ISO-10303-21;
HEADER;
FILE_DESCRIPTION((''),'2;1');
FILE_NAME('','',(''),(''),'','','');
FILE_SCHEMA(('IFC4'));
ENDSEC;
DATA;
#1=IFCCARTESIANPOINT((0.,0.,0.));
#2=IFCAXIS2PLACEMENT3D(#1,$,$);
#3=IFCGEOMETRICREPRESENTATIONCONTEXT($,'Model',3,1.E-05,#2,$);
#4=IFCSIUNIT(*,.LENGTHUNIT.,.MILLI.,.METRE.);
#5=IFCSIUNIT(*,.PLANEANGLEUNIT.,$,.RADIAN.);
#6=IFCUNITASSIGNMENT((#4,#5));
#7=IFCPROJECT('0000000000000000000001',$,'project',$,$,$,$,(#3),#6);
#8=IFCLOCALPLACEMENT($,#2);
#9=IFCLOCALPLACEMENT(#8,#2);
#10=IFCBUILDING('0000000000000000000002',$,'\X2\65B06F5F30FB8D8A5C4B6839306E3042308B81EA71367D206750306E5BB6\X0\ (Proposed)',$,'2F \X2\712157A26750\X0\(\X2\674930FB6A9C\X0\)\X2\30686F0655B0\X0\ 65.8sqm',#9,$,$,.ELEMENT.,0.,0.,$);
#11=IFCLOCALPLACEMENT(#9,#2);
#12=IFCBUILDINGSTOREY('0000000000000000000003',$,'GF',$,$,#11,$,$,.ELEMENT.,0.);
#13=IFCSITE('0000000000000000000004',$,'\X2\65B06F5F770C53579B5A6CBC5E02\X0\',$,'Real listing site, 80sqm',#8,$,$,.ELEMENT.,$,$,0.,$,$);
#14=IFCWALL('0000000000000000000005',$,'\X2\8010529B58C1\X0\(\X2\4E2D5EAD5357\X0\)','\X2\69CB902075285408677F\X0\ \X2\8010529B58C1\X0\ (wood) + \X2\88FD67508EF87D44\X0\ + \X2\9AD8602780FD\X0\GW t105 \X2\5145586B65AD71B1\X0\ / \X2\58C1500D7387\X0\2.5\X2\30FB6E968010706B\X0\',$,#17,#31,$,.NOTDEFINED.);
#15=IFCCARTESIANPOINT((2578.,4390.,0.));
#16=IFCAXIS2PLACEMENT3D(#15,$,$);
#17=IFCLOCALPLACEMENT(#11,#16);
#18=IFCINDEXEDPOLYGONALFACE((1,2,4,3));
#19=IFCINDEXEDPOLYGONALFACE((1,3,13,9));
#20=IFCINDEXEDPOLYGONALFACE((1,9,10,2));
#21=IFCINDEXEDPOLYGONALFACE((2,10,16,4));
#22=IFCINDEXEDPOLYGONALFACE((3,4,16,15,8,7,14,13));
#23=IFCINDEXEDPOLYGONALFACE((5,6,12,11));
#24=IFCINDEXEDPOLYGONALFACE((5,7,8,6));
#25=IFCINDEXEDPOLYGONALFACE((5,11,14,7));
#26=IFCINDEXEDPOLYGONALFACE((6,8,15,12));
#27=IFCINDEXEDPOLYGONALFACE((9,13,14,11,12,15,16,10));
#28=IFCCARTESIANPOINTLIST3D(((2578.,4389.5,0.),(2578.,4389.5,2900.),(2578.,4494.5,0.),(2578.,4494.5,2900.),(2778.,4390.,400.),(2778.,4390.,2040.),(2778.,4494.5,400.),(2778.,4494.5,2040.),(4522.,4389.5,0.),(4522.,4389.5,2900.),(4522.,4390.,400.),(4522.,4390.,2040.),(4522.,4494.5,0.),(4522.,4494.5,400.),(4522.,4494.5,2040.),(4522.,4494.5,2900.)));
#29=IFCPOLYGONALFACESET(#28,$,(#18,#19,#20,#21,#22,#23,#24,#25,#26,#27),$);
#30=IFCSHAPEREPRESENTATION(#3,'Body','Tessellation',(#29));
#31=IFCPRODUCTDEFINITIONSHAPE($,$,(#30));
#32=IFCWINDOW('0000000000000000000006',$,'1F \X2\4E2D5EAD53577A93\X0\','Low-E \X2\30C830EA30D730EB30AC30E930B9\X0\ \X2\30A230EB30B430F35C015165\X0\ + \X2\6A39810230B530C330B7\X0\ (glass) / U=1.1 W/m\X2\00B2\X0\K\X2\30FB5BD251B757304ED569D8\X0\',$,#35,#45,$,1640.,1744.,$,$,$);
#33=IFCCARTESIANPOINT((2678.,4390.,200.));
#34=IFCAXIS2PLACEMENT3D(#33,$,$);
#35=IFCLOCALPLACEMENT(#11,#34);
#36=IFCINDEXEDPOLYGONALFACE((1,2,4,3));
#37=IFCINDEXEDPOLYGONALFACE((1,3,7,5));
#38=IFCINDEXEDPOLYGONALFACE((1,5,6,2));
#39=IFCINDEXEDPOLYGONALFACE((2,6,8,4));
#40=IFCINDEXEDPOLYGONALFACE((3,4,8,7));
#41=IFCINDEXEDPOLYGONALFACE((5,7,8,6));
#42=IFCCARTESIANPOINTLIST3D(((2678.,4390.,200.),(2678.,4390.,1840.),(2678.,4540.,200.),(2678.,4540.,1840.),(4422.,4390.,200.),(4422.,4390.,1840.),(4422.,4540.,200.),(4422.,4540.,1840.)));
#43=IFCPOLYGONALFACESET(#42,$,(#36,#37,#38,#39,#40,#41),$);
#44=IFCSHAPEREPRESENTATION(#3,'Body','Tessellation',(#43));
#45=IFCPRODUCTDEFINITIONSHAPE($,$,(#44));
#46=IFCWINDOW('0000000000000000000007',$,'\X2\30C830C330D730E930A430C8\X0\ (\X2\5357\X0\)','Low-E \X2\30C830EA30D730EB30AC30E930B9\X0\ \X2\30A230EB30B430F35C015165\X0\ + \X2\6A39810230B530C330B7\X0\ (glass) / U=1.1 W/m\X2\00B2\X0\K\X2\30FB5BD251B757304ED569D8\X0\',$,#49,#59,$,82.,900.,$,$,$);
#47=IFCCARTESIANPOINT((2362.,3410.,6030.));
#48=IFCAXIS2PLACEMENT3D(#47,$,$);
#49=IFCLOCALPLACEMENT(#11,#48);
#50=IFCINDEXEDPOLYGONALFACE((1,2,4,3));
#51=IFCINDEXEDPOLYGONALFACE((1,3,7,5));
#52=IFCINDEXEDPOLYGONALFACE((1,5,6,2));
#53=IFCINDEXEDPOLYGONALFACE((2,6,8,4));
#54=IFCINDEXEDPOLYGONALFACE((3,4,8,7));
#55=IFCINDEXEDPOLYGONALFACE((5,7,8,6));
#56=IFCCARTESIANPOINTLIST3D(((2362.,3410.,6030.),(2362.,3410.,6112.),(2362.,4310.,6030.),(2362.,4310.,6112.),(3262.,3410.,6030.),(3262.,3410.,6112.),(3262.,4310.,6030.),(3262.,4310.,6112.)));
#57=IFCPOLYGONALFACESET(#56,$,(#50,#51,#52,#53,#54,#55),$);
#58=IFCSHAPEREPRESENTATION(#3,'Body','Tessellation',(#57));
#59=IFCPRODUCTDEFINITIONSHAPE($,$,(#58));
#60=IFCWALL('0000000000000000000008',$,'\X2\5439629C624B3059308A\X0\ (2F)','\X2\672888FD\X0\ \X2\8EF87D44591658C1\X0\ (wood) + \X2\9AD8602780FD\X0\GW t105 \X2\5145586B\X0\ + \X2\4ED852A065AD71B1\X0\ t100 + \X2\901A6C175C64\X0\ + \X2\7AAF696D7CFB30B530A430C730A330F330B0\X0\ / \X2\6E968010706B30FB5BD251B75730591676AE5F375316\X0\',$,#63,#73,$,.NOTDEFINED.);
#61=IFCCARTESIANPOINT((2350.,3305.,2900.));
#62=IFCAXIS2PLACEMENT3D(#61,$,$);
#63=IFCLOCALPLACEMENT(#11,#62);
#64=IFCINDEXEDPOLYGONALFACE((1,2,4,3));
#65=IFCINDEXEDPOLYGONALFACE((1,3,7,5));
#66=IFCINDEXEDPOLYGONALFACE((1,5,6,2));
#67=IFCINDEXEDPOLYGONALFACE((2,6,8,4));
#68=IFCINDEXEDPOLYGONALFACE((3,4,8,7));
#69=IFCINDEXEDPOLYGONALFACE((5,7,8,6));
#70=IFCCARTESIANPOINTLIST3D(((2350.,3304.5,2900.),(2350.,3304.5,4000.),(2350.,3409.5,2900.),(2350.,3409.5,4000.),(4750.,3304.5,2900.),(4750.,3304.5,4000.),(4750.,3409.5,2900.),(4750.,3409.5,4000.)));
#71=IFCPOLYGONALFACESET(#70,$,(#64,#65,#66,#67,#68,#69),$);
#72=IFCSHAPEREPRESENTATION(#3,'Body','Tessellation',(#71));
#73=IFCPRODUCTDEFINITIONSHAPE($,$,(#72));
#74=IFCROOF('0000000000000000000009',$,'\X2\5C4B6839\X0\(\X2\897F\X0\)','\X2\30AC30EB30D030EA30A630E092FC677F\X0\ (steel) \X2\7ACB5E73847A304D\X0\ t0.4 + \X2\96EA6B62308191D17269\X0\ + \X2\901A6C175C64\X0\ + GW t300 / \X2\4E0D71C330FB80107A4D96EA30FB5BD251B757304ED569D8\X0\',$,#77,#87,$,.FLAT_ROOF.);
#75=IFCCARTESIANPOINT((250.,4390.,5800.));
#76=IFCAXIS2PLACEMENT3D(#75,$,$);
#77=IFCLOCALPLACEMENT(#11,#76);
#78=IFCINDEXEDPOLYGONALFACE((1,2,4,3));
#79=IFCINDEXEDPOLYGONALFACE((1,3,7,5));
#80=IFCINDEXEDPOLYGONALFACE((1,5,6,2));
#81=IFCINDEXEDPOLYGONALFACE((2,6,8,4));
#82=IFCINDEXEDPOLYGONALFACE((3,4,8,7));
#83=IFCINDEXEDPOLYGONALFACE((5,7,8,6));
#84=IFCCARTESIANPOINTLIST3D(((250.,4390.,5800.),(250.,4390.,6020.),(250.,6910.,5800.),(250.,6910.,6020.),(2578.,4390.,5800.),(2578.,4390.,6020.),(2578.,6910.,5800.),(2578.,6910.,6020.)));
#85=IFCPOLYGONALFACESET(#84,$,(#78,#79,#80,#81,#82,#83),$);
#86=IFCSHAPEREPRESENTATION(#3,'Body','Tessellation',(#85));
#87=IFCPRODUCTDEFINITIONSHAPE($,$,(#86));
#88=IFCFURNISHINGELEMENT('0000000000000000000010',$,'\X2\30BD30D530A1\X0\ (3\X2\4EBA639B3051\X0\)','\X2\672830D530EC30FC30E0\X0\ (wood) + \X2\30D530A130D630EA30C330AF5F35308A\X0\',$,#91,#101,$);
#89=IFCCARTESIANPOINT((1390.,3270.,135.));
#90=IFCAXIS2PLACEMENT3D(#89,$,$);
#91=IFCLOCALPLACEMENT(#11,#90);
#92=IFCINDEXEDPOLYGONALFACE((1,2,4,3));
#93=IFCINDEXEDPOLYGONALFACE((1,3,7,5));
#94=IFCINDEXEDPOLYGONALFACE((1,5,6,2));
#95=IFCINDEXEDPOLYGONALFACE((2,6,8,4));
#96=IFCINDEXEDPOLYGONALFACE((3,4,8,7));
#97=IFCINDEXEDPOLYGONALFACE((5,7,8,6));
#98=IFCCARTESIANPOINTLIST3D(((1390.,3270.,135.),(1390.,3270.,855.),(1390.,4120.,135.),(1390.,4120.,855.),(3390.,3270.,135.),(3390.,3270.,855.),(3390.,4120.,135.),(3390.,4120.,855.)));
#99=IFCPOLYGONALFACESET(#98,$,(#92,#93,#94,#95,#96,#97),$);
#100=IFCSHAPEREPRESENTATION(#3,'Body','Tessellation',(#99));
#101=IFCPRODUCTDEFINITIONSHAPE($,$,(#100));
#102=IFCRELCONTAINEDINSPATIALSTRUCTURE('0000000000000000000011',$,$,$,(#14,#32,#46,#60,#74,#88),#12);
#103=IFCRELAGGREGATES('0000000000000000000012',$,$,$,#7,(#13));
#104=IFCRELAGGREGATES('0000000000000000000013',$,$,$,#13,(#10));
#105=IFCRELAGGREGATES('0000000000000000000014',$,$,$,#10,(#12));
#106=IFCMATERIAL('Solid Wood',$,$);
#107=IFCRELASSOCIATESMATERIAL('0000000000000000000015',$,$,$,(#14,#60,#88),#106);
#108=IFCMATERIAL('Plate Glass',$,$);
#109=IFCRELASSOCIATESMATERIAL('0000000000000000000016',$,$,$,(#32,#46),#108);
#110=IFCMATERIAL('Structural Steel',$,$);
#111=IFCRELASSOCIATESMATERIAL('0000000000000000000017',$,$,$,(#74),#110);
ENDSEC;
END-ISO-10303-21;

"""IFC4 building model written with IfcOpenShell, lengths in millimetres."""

from ifc_helpers import new_model, si_unit, frame, frame_2d, origin, place, context, project, spatial, rectangle, extrude, material, element, fill, save


model = new_model("IFC4")

# Units and contexts
model_context = context("Model", 3, precision=1e-05, world=origin())
ifc_project = project(units=[si_unit("LENGTHUNIT", "METRE", prefix="MILLI"), si_unit("PLANEANGLEUNIT", "RADIAN")], contexts=[model_context])

# Site, building, storey
site_placement = place(None, origin())
site = spatial("IfcSite", under=ifc_project, at=site_placement, Name="新潟県南魚沼市", ObjectType="Real listing site, 80sqm", CompositionType="ELEMENT", RefElevation=0.0)
building_placement = place(site_placement, origin())
building = spatial("IfcBuilding", under=site, at=building_placement, Name="新潟・越屋根のある自然素材の家 (Proposed)", ObjectType="2F 無垢材(杉・檜)と漆喰 65.8sqm", CompositionType="ELEMENT", ElevationOfRefHeight=0.0, ElevationOfTerrain=0.0)
storey_placement = place(building_placement, origin())
storey = spatial("IfcBuildingStorey", under=building, at=storey_placement, Name="GF", CompositionType="ELEMENT", Elevation=0.0)

# Shared definitions
ifc_material_1 = material(Name="Solid Wood")

# Wall, opening, window
wall_1_placement = place(storey_placement, frame((2578.0, 4390.0, 0.0)))
wall_1 = element("IfcWall", 1, at=wall_1_placement, inside=storey, material=ifc_material_1, Name="耐力壁(中庭南)", Description="構造用合板 耐力壁 (wood) + 製材軸組 + 高性能GW t105 充填断熱 / 壁倍率2.5・準耐火", PredefinedType="NOTDEFINED", context=model_context, shape_type="SweptSolid", body=[
    extrude(rectangle(XDim=1944.0, YDim=105.0, at=frame_2d((972.0, 52.0))), frame((2578.0, 4390.0, 0.0)), (0.0, 0.0, 1.0), 2900.0),
])
opening_placement = place(storey_placement, frame((2678.0, 4390.0, 200.0)))
opening = element("IfcOpeningElement", 2, at=opening_placement, cuts=wall_1, PredefinedType="NOTDEFINED", context=model_context, shape_type="SweptSolid", body=[
    extrude(rectangle(XDim=1744.0, YDim=150.0, at=frame_2d((872.0, 75.0))), frame((2678.0, 4390.0, 200.0)), (0.0, 0.0, 1.0), 1640.0),
])
ifc_material_2 = material(Name="Plate Glass")
window_1_placement = place(storey_placement, frame((2678.0, 4390.0, 200.0)))
window_1 = element("IfcWindow", 3, at=window_1_placement, inside=storey, material=ifc_material_2, Name="1F 中庭南窓", Description="Low-E トリプルガラス アルゴン封入 + 樹脂サッシ (glass) / U=1.1 W/m²K・寒冷地仕様", OverallHeight=1640.0, OverallWidth=1744.0, context=model_context, shape_type="SweptSolid", body=[
    extrude(rectangle(XDim=1744.0, YDim=150.0, at=frame_2d((872.0, 75.0))), frame((2678.0, 4390.0, 200.0)), (0.0, 0.0, 1.0), 1640.0),
])
fill(opening, window_1)

# Window
window_2_placement = place(storey_placement, frame((2362.0, 3410.0, 6030.0)))
element("IfcWindow", 4, at=window_2_placement, inside=storey, material=ifc_material_2, Name="トップライト (南)", Description="Low-E トリプルガラス アルゴン封入 + 樹脂サッシ (glass) / U=1.1 W/m²K・寒冷地仕様", OverallHeight=82.0, OverallWidth=900.0, context=model_context, shape_type="SweptSolid", body=[
    extrude(rectangle(XDim=900.0, YDim=900.0, at=frame_2d((450.0, 450.0))), frame((2362.0, 3410.0, 6030.0)), (0.0, 0.0, 1.0), 82.0),
])

# Wall
wall_2_placement = place(storey_placement, frame((2350.0, 3305.0, 2900.0)))
element("IfcWall", 5, at=wall_2_placement, inside=storey, material=ifc_material_1, Name="吹抜手すり (2F)", Description="木製 軸組外壁 (wood) + 高性能GW t105 充填 + 付加断熱 t100 + 通気層 + 窯業系サイディング / 準耐火・寒冷地外皮強化", PredefinedType="NOTDEFINED", context=model_context, shape_type="SweptSolid", body=[
    extrude(rectangle(XDim=2400.0, YDim=105.0, at=frame_2d((1200.0, 52.0))), frame((2350.0, 3305.0, 2900.0)), (0.0, 0.0, 1.0), 1100.0),
])

# Roof
ifc_material_3 = material(Name="Structural Steel")
for number, where, name in (
    (6, (250.0, 4390.0, 5800.0), "屋根(西)"),
):
    element("IfcRoof", number, at=place(storey_placement, frame(where)), inside=storey, material=ifc_material_3, Name=name, Description="ガルバリウム鋼板 (steel) 立平葺き t0.4 + 雪止め金物 + 通気層 + GW t300 / 不燃・耐積雪・寒冷地仕様", PredefinedType="FLAT_ROOF", context=model_context, shape_type="SweptSolid", body=[
        extrude(rectangle(XDim=2328.0, YDim=2520.0, at=frame_2d((1164.0, 1260.0))), frame((250.0, 4390.0, 5800.0)), (0.0, 0.0, 1.0), 220.0),
    ])

# Furnishing element
furnishing_placement = place(storey_placement, frame((1390.0, 3270.0, 135.0)))
element("IfcFurnishingElement", 7, at=furnishing_placement, inside=storey, material=ifc_material_1, Name="ソファ (3人掛け)", Description="木フレーム (wood) + ファブリック張り", context=model_context, shape_type="SweptSolid", body=[
    extrude(rectangle(XDim=2000.0, YDim=850.0, at=frame_2d((1000.0, 425.0))), frame((1390.0, 3270.0, 135.0)), (0.0, 0.0, 1.0), 720.0),
])

save(model, "model.ifc")
